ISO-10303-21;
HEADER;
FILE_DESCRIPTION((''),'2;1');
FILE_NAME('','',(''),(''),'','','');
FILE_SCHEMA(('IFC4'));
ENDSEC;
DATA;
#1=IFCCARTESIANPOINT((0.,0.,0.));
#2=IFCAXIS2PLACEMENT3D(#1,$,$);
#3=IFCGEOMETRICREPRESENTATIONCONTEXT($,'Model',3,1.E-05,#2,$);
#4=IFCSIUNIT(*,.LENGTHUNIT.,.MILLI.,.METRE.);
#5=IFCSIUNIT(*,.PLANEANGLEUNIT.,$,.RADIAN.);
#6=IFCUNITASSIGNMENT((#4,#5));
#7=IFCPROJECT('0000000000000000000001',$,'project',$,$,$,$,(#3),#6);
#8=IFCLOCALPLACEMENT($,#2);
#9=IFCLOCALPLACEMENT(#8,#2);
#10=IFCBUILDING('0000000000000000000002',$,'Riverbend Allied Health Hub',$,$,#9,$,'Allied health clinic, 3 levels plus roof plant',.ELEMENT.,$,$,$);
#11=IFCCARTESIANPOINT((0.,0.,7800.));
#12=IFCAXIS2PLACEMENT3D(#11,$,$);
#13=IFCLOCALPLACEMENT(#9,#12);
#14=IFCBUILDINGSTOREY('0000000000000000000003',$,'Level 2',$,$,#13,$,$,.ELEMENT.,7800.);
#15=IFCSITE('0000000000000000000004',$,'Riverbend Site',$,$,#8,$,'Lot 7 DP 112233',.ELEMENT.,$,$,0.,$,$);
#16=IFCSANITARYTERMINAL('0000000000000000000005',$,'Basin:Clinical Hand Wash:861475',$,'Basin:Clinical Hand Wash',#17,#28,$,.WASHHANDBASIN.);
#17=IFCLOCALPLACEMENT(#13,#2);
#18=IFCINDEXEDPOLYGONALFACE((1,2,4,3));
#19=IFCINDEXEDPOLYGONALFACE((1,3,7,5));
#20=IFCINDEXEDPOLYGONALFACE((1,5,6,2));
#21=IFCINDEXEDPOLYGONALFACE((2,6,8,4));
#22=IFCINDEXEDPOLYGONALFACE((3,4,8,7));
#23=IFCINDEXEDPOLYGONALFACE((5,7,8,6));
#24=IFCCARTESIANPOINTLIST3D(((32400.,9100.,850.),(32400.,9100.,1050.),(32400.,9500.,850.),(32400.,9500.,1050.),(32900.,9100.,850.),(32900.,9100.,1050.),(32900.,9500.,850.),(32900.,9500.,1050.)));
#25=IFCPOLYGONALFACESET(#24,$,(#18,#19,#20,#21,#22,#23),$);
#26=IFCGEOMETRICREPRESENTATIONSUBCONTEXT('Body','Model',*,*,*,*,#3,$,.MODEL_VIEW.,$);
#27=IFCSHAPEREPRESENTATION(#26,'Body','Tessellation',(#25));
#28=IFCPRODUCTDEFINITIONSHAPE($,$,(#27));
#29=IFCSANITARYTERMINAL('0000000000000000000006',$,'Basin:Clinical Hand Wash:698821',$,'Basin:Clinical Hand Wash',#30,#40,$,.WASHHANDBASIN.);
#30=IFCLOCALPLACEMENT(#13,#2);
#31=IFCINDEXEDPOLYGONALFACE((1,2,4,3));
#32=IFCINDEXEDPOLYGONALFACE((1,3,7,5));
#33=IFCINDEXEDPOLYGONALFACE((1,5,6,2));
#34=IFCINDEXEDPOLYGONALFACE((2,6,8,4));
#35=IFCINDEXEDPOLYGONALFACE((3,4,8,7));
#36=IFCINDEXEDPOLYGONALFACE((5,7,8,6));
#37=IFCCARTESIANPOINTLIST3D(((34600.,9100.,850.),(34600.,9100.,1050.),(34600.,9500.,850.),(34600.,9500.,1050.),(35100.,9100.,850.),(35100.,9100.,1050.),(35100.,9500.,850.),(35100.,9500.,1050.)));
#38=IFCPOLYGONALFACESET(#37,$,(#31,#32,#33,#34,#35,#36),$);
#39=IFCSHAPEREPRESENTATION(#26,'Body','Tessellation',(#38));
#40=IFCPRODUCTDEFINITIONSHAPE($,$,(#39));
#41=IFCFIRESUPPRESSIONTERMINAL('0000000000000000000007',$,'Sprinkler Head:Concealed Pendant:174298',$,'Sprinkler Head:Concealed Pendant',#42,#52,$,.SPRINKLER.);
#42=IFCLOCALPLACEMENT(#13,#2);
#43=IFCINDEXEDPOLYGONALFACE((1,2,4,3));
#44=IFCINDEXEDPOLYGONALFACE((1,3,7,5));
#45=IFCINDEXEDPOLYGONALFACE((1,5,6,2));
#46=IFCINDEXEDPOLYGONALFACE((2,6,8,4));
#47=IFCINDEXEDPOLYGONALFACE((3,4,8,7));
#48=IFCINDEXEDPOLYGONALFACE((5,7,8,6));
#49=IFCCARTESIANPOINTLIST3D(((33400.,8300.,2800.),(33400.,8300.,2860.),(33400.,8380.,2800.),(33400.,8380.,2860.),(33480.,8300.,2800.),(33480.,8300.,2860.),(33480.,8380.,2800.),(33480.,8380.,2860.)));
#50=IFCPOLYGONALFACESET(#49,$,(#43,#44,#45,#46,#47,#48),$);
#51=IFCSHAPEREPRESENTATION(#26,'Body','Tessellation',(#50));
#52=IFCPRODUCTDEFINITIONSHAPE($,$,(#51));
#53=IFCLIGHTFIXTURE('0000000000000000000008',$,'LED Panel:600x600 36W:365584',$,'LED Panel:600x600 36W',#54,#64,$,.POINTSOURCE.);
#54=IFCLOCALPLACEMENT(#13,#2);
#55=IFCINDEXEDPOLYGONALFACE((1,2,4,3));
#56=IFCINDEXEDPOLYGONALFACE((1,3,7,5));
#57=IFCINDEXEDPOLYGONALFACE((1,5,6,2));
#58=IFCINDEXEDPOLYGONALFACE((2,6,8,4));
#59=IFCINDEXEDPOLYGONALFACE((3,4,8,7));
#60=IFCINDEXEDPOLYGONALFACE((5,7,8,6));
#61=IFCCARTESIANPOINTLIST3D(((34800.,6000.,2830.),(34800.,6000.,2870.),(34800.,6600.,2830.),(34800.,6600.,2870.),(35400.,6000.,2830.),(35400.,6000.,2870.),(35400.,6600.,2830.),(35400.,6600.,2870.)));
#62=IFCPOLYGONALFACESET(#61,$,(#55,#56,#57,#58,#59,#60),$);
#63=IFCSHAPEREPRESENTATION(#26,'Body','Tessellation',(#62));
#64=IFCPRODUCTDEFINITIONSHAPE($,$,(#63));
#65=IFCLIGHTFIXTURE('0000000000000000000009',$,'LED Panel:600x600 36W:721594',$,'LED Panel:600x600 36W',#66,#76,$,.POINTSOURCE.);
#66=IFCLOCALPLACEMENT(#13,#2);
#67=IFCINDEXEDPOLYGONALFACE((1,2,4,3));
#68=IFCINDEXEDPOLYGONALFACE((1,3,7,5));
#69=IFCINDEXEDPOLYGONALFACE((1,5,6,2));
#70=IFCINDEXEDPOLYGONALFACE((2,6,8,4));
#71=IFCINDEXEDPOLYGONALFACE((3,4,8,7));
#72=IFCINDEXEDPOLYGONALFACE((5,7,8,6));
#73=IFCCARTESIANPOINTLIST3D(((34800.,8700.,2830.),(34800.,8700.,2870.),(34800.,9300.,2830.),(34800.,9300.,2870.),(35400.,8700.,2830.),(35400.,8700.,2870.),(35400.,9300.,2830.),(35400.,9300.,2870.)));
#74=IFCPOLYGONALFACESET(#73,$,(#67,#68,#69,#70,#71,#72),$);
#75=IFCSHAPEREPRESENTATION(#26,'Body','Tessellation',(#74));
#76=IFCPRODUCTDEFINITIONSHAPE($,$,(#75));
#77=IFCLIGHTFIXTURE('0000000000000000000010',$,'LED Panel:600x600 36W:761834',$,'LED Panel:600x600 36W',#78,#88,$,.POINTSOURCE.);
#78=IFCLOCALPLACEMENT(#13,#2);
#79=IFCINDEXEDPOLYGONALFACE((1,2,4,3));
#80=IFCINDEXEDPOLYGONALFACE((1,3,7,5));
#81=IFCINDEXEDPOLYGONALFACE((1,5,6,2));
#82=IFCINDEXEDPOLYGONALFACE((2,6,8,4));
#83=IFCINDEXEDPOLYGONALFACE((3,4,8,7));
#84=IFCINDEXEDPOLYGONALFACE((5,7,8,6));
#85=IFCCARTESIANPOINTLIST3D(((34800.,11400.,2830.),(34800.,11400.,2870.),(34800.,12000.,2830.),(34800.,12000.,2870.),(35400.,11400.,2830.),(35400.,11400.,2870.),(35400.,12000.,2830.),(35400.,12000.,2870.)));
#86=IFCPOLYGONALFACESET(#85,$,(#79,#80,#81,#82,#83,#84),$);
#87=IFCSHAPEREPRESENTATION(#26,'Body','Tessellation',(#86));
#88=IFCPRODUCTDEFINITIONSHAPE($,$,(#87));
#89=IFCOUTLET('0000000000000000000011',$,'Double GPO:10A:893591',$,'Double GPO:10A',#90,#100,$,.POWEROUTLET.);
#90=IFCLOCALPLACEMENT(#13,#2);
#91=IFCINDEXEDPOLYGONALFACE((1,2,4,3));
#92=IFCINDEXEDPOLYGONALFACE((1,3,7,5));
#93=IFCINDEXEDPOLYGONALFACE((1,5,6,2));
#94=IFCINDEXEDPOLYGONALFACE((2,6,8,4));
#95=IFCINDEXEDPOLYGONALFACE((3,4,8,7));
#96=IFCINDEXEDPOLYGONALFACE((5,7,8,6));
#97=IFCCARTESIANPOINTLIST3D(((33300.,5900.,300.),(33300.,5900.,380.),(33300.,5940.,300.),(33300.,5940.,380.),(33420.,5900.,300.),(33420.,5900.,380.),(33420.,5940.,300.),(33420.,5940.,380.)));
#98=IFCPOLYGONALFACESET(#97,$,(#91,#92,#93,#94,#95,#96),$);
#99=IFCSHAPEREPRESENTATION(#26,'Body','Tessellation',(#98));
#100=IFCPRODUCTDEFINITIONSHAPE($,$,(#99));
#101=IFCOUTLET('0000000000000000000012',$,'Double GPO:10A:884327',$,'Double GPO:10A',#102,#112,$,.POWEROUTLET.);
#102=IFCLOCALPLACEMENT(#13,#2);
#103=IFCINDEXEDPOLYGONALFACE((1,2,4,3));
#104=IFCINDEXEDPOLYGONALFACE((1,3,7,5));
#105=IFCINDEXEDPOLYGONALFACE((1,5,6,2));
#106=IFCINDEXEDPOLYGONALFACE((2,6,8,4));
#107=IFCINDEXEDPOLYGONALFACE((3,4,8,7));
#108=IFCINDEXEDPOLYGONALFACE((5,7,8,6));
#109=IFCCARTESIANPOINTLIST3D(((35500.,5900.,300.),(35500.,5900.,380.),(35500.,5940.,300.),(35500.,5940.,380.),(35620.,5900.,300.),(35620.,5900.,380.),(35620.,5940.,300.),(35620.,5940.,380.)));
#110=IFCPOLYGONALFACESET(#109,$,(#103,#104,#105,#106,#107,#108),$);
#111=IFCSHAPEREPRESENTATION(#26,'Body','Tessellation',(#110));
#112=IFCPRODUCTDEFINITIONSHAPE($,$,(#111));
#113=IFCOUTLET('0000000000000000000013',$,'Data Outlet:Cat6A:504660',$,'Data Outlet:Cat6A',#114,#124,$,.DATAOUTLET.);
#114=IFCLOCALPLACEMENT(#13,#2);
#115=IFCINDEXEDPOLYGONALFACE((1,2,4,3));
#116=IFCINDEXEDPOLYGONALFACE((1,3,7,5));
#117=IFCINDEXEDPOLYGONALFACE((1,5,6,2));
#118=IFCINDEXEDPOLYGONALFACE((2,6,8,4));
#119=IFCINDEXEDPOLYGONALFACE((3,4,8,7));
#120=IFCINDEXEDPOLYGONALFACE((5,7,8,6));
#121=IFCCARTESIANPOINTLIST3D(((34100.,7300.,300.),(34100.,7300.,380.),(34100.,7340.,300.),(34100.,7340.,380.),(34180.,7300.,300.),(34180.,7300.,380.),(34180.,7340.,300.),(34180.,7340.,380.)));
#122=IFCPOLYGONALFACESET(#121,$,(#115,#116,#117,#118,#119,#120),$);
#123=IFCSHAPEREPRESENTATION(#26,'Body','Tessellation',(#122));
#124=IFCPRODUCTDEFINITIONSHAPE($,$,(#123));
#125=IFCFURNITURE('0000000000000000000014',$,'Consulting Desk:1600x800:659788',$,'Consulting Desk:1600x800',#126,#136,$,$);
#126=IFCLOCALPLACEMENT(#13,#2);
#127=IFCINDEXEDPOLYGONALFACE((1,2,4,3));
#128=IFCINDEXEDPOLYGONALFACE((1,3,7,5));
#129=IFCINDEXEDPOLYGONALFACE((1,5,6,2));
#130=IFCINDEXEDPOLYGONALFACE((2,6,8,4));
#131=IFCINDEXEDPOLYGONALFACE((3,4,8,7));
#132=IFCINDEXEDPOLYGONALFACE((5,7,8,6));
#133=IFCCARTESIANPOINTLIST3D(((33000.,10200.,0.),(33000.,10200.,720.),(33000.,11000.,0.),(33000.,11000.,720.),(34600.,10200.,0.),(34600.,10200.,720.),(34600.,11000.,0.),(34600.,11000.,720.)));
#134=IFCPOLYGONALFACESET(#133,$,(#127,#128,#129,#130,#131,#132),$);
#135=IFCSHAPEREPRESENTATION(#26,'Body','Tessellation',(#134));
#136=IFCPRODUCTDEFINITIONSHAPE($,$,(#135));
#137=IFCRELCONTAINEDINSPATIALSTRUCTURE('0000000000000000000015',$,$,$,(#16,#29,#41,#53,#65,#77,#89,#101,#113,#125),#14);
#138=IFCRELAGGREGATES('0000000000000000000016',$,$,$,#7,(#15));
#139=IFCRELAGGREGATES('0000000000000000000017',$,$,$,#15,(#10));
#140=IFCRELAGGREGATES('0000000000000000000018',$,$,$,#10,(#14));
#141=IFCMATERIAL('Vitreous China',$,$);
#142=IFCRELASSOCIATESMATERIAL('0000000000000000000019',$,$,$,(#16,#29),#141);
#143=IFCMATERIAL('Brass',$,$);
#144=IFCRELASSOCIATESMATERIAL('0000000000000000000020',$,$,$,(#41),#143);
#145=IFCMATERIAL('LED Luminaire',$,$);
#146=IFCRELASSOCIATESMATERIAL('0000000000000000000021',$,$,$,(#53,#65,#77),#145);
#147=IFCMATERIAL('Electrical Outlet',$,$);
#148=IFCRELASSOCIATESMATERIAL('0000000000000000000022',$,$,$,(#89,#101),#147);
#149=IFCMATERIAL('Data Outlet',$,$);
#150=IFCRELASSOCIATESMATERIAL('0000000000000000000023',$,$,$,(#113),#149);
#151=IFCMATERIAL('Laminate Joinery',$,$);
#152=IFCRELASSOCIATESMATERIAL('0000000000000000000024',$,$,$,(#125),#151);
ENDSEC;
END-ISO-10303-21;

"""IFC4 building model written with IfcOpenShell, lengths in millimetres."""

from ifc_helpers import new_model, si_unit, frame, frame_2d, origin, place, context, subcontext, project, spatial, rectangle, extrude, material, element, save


model = new_model("IFC4")

# Units and contexts
model_context = context("Model", 3, precision=1e-05, world=origin())
body_context = subcontext(model_context, "Body", "Model", "MODEL_VIEW")
ifc_project = project(units=[si_unit("LENGTHUNIT", "METRE", prefix="MILLI"), si_unit("PLANEANGLEUNIT", "RADIAN")], contexts=[model_context])

# Site, building, storey
site_placement = place(None, origin())
site = spatial("IfcSite", under=ifc_project, at=site_placement, Name="Riverbend Site", LongName="Lot 7 DP 112233", CompositionType="ELEMENT", RefElevation=0.0)
building_placement = place(site_placement, origin())
building = spatial("IfcBuilding", under=site, at=building_placement, Name="Riverbend Allied Health Hub", LongName="Allied health clinic, 3 levels plus roof plant", CompositionType="ELEMENT")
storey_placement = place(building_placement, frame((0.0, 0.0, 7800.0)))
storey = spatial("IfcBuildingStorey", under=building, at=storey_placement, Name="Level 2", CompositionType="ELEMENT", Elevation=7800.0)

# Sanitary terminals
ifc_material_1 = material(Name="Vitreous China")
for number, where, name in (
    (1, (32400.0, 9100.0, 850.0), "Basin:Clinical Hand Wash:861475"),
    (2, (34600.0, 9100.0, 850.0), "Basin:Clinical Hand Wash:698821"),
):
    element("IfcSanitaryTerminal", number, at=place(storey_placement, frame(where)), inside=storey, material=ifc_material_1, Name=name, ObjectType="Basin:Clinical Hand Wash", PredefinedType="WASHHANDBASIN", context=body_context, shape_type="SweptSolid", body=[
        extrude(rectangle(XDim=500.0, YDim=400.0, at=frame_2d((250.0, 200.0))), origin(), (0.0, 0.0, 1.0), 200.0),
    ])

# Fire suppression terminal
ifc_material_2 = material(Name="Brass")
fire_suppression_terminal_placement = place(storey_placement, frame((33400.0, 8300.0, 2800.0)))
element("IfcFireSuppressionTerminal", 3, at=fire_suppression_terminal_placement, inside=storey, material=ifc_material_2, Name="Sprinkler Head:Concealed Pendant:174298", ObjectType="Sprinkler Head:Concealed Pendant", PredefinedType="SPRINKLER", context=body_context, shape_type="SweptSolid", body=[
    extrude(rectangle(XDim=80.0, YDim=80.0, at=frame_2d((40.0, 40.0))), origin(), (0.0, 0.0, 1.0), 60.0),
])

# Light fixtures
ifc_material_3 = material(Name="LED Luminaire")
for number, where, name in (
    (4, (34800.0, 6000.0, 2830.0), "LED Panel:600x600 36W:365584"),
    (5, (34800.0, 8700.0, 2830.0), "LED Panel:600x600 36W:721594"),
    (6, (34800.0, 11400.0, 2830.0), "LED Panel:600x600 36W:761834"),
):
    element("IfcLightFixture", number, at=place(storey_placement, frame(where)), inside=storey, material=ifc_material_3, Name=name, ObjectType="LED Panel:600x600 36W", PredefinedType="POINTSOURCE", context=body_context, shape_type="SweptSolid", body=[
        extrude(rectangle(XDim=600.0, YDim=600.0, at=frame_2d((300.0, 300.0))), origin(), (0.0, 0.0, 1.0), 40.0),
    ])

# Outlets
ifc_material_4 = material(Name="Electrical Outlet")
for number, where, name in (
    (7, (33300.0, 5900.0, 300.0), "Double GPO:10A:893591"),
    (8, (35500.0, 5900.0, 300.0), "Double GPO:10A:884327"),
):
    element("IfcOutlet", number, at=place(storey_placement, frame(where)), inside=storey, material=ifc_material_4, Name=name, ObjectType="Double GPO:10A", PredefinedType="POWEROUTLET", context=body_context, shape_type="SweptSolid", body=[
        extrude(rectangle(XDim=120.0, YDim=40.0, at=frame_2d((60.0, 20.0))), origin(), (0.0, 0.0, 1.0), 80.0),
    ])
ifc_material_5 = material(Name="Data Outlet")
outlet_placement = place(storey_placement, frame((34100.0, 7300.0, 300.0)))
element("IfcOutlet", 9, at=outlet_placement, inside=storey, material=ifc_material_5, Name="Data Outlet:Cat6A:504660", ObjectType="Data Outlet:Cat6A", PredefinedType="DATAOUTLET", context=body_context, shape_type="SweptSolid", body=[
    extrude(rectangle(XDim=80.0, YDim=40.0, at=frame_2d((40.0, 20.0))), origin(), (0.0, 0.0, 1.0), 80.0),
])

# Furniture
ifc_material_6 = material(Name="Laminate Joinery")
furniture_placement = place(storey_placement, frame((33000.0, 10200.0, 0.0)))
element("IfcFurniture", 10, at=furniture_placement, inside=storey, material=ifc_material_6, Name="Consulting Desk:1600x800:659788", ObjectType="Consulting Desk:1600x800", context=body_context, shape_type="SweptSolid", body=[
    extrude(rectangle(XDim=1600.0, YDim=800.0, at=frame_2d((800.0, 400.0))), origin(), (0.0, 0.0, 1.0), 720.0),
])

save(model, "model.ifc")
